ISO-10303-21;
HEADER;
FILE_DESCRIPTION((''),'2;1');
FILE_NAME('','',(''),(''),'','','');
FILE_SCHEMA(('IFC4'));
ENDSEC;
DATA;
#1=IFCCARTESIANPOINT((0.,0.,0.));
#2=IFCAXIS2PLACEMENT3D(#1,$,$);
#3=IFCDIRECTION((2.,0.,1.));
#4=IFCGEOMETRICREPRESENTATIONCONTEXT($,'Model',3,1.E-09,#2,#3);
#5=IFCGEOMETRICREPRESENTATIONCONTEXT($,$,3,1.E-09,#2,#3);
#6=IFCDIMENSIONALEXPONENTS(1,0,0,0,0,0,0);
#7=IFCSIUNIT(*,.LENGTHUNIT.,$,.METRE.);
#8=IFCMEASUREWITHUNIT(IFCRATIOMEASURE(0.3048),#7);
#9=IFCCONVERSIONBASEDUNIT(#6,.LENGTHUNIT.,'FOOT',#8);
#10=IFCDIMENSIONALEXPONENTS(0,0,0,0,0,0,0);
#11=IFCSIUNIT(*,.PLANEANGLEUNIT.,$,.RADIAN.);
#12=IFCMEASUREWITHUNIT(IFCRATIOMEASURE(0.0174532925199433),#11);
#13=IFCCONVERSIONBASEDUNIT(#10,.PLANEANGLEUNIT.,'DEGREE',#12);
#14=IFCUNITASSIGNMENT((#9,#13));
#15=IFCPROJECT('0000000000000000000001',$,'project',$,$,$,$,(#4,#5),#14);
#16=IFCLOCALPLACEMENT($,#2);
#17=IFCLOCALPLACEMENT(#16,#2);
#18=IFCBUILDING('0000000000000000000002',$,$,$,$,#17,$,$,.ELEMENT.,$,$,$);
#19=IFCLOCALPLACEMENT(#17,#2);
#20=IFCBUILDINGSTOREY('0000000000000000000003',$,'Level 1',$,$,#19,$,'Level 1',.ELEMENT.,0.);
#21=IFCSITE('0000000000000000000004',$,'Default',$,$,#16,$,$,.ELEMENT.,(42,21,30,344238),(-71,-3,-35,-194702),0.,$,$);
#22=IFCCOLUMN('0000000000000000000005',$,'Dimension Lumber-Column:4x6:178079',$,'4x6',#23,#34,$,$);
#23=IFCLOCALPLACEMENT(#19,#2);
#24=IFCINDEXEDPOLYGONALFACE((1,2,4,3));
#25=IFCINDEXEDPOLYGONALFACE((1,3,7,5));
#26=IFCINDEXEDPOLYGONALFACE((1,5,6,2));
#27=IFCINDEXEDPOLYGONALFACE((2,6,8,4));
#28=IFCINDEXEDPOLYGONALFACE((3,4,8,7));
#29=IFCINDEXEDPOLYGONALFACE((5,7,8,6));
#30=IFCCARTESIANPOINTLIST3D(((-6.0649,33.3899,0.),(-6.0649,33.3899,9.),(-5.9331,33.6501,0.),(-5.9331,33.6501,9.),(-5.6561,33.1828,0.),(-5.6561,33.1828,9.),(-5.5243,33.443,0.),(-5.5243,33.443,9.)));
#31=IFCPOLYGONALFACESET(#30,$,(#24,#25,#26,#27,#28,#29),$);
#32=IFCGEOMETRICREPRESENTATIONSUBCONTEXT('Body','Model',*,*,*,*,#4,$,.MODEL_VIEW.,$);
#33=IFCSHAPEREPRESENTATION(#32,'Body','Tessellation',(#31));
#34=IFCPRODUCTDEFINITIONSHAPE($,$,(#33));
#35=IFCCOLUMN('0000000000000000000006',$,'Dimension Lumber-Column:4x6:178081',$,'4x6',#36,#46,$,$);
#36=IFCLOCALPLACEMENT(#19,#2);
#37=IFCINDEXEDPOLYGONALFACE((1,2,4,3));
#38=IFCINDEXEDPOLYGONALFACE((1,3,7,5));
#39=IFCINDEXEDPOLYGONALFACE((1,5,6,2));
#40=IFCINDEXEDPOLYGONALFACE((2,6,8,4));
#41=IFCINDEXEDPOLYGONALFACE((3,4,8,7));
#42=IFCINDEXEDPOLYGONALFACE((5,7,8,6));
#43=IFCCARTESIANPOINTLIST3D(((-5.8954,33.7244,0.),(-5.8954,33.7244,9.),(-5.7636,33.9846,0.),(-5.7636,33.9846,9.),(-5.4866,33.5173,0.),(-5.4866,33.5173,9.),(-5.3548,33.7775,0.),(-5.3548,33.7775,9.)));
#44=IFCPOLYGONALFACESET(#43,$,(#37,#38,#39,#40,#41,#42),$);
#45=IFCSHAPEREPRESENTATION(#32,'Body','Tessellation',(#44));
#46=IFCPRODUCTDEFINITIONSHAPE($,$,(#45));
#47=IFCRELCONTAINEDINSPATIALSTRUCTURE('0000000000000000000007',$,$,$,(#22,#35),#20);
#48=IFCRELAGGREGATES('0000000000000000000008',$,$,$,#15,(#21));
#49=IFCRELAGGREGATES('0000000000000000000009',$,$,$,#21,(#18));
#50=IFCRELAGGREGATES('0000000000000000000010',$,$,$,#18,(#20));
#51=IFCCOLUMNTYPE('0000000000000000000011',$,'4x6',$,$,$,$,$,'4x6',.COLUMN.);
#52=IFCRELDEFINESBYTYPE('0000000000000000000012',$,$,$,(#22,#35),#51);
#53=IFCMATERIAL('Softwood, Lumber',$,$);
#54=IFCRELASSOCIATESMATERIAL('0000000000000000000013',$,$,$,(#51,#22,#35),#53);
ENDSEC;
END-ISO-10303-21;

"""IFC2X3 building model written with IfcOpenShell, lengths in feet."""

from ifc_helpers import new_model, entity, si_unit, converted_unit, direction, frame, origin, origin_2d_with_axis, place, context, subcontext, project, spatial, rectangle, extrude, source, transform, mapped, material, type_object, type_shapes, element, save


model = new_model("IFC2X3")

# Units and contexts
model_context = context("Model", 3, precision=1e-09, world=origin(), true_north=direction((2.0, 0.0, 1.0)))
context_of_model = context(None, 3, precision=1e-09, world=origin(), true_north=direction((2.0, 0.0, 1.0)))
body_context = subcontext(model_context, "Body", "Model", "MODEL_VIEW")
ifc_project = project(units=[converted_unit("LENGTHUNIT", "FOOT", entity("IfcRatioMeasure", 0.3048), si_unit("LENGTHUNIT", "METRE"), dimensions=[1, 0, 0, 0, 0, 0, 0]), converted_unit("PLANEANGLEUNIT", "DEGREE", entity("IfcRatioMeasure", 0.0174532925199433), si_unit("PLANEANGLEUNIT", "RADIAN"), dimensions=[0, 0, 0, 0, 0, 0, 0])], contexts=[model_context, context_of_model])

# Site, building, storey
site_placement = place(None, origin())
site = spatial("IfcSite", under=ifc_project, at=site_placement, Name="Default", CompositionType="ELEMENT", RefLatitude=(42, 21, 30, 344238), RefLongitude=(-71, -3, -35, -194702), RefElevation=0.0)
building_placement = place(site_placement, origin())
building = spatial("IfcBuilding", under=site, at=building_placement, CompositionType="ELEMENT")
storey_placement = place(building_placement, origin())
storey = spatial("IfcBuildingStorey", under=building, at=storey_placement, Name="Level 1", LongName="Level 1", CompositionType="ELEMENT", Elevation=0.0)

# Columns
ifc_material_1 = material(Name="Softwood, Lumber")
column_type = type_object("IfcColumnType", Name="4x6", ElementType="4x6", PredefinedType="COLUMN", material=ifc_material_1)
shared_shape_1 = source(origin(), body_context, "Body", "SweptSolid", [
    extrude(rectangle(XDim=0.2917, YDim=0.4583, at=origin_2d_with_axis()), frame((0.0, 0.0, 0.0), z_axis=(0.0, 0.0, 1.0), x_axis=(-1.0, 0.0, 0.0)), (0.0, 0.0, 1.0), 9.0),
])
type_shapes(column_type, [shared_shape_1])
for number, where, z_axis, x_axis, name in (
    (1, (-5.7946, 33.4164, 0.0), (0.0, 0.0, 1.0), (0.451968, 0.892034, 0.0), "Dimension Lumber-Column:4x6:178079"),
    (2, (-5.6251, 33.751, 0.0), (0.0, 0.0, 1.0), (0.451968, 0.892034, 0.0), "Dimension Lumber-Column:4x6:178081"),
):
    element("IfcColumn", number, at=place(storey_placement, frame(where, z_axis=z_axis, x_axis=x_axis)), inside=storey, type_object=column_type, material=ifc_material_1, Name=name, ObjectType="4x6", context=body_context, shape_type="MappedRepresentation", body=[
        mapped(shared_shape_1, transform((0.0, 0.0, 0.0), scale=1.0)),
    ])

save(model, "model.ifc")
